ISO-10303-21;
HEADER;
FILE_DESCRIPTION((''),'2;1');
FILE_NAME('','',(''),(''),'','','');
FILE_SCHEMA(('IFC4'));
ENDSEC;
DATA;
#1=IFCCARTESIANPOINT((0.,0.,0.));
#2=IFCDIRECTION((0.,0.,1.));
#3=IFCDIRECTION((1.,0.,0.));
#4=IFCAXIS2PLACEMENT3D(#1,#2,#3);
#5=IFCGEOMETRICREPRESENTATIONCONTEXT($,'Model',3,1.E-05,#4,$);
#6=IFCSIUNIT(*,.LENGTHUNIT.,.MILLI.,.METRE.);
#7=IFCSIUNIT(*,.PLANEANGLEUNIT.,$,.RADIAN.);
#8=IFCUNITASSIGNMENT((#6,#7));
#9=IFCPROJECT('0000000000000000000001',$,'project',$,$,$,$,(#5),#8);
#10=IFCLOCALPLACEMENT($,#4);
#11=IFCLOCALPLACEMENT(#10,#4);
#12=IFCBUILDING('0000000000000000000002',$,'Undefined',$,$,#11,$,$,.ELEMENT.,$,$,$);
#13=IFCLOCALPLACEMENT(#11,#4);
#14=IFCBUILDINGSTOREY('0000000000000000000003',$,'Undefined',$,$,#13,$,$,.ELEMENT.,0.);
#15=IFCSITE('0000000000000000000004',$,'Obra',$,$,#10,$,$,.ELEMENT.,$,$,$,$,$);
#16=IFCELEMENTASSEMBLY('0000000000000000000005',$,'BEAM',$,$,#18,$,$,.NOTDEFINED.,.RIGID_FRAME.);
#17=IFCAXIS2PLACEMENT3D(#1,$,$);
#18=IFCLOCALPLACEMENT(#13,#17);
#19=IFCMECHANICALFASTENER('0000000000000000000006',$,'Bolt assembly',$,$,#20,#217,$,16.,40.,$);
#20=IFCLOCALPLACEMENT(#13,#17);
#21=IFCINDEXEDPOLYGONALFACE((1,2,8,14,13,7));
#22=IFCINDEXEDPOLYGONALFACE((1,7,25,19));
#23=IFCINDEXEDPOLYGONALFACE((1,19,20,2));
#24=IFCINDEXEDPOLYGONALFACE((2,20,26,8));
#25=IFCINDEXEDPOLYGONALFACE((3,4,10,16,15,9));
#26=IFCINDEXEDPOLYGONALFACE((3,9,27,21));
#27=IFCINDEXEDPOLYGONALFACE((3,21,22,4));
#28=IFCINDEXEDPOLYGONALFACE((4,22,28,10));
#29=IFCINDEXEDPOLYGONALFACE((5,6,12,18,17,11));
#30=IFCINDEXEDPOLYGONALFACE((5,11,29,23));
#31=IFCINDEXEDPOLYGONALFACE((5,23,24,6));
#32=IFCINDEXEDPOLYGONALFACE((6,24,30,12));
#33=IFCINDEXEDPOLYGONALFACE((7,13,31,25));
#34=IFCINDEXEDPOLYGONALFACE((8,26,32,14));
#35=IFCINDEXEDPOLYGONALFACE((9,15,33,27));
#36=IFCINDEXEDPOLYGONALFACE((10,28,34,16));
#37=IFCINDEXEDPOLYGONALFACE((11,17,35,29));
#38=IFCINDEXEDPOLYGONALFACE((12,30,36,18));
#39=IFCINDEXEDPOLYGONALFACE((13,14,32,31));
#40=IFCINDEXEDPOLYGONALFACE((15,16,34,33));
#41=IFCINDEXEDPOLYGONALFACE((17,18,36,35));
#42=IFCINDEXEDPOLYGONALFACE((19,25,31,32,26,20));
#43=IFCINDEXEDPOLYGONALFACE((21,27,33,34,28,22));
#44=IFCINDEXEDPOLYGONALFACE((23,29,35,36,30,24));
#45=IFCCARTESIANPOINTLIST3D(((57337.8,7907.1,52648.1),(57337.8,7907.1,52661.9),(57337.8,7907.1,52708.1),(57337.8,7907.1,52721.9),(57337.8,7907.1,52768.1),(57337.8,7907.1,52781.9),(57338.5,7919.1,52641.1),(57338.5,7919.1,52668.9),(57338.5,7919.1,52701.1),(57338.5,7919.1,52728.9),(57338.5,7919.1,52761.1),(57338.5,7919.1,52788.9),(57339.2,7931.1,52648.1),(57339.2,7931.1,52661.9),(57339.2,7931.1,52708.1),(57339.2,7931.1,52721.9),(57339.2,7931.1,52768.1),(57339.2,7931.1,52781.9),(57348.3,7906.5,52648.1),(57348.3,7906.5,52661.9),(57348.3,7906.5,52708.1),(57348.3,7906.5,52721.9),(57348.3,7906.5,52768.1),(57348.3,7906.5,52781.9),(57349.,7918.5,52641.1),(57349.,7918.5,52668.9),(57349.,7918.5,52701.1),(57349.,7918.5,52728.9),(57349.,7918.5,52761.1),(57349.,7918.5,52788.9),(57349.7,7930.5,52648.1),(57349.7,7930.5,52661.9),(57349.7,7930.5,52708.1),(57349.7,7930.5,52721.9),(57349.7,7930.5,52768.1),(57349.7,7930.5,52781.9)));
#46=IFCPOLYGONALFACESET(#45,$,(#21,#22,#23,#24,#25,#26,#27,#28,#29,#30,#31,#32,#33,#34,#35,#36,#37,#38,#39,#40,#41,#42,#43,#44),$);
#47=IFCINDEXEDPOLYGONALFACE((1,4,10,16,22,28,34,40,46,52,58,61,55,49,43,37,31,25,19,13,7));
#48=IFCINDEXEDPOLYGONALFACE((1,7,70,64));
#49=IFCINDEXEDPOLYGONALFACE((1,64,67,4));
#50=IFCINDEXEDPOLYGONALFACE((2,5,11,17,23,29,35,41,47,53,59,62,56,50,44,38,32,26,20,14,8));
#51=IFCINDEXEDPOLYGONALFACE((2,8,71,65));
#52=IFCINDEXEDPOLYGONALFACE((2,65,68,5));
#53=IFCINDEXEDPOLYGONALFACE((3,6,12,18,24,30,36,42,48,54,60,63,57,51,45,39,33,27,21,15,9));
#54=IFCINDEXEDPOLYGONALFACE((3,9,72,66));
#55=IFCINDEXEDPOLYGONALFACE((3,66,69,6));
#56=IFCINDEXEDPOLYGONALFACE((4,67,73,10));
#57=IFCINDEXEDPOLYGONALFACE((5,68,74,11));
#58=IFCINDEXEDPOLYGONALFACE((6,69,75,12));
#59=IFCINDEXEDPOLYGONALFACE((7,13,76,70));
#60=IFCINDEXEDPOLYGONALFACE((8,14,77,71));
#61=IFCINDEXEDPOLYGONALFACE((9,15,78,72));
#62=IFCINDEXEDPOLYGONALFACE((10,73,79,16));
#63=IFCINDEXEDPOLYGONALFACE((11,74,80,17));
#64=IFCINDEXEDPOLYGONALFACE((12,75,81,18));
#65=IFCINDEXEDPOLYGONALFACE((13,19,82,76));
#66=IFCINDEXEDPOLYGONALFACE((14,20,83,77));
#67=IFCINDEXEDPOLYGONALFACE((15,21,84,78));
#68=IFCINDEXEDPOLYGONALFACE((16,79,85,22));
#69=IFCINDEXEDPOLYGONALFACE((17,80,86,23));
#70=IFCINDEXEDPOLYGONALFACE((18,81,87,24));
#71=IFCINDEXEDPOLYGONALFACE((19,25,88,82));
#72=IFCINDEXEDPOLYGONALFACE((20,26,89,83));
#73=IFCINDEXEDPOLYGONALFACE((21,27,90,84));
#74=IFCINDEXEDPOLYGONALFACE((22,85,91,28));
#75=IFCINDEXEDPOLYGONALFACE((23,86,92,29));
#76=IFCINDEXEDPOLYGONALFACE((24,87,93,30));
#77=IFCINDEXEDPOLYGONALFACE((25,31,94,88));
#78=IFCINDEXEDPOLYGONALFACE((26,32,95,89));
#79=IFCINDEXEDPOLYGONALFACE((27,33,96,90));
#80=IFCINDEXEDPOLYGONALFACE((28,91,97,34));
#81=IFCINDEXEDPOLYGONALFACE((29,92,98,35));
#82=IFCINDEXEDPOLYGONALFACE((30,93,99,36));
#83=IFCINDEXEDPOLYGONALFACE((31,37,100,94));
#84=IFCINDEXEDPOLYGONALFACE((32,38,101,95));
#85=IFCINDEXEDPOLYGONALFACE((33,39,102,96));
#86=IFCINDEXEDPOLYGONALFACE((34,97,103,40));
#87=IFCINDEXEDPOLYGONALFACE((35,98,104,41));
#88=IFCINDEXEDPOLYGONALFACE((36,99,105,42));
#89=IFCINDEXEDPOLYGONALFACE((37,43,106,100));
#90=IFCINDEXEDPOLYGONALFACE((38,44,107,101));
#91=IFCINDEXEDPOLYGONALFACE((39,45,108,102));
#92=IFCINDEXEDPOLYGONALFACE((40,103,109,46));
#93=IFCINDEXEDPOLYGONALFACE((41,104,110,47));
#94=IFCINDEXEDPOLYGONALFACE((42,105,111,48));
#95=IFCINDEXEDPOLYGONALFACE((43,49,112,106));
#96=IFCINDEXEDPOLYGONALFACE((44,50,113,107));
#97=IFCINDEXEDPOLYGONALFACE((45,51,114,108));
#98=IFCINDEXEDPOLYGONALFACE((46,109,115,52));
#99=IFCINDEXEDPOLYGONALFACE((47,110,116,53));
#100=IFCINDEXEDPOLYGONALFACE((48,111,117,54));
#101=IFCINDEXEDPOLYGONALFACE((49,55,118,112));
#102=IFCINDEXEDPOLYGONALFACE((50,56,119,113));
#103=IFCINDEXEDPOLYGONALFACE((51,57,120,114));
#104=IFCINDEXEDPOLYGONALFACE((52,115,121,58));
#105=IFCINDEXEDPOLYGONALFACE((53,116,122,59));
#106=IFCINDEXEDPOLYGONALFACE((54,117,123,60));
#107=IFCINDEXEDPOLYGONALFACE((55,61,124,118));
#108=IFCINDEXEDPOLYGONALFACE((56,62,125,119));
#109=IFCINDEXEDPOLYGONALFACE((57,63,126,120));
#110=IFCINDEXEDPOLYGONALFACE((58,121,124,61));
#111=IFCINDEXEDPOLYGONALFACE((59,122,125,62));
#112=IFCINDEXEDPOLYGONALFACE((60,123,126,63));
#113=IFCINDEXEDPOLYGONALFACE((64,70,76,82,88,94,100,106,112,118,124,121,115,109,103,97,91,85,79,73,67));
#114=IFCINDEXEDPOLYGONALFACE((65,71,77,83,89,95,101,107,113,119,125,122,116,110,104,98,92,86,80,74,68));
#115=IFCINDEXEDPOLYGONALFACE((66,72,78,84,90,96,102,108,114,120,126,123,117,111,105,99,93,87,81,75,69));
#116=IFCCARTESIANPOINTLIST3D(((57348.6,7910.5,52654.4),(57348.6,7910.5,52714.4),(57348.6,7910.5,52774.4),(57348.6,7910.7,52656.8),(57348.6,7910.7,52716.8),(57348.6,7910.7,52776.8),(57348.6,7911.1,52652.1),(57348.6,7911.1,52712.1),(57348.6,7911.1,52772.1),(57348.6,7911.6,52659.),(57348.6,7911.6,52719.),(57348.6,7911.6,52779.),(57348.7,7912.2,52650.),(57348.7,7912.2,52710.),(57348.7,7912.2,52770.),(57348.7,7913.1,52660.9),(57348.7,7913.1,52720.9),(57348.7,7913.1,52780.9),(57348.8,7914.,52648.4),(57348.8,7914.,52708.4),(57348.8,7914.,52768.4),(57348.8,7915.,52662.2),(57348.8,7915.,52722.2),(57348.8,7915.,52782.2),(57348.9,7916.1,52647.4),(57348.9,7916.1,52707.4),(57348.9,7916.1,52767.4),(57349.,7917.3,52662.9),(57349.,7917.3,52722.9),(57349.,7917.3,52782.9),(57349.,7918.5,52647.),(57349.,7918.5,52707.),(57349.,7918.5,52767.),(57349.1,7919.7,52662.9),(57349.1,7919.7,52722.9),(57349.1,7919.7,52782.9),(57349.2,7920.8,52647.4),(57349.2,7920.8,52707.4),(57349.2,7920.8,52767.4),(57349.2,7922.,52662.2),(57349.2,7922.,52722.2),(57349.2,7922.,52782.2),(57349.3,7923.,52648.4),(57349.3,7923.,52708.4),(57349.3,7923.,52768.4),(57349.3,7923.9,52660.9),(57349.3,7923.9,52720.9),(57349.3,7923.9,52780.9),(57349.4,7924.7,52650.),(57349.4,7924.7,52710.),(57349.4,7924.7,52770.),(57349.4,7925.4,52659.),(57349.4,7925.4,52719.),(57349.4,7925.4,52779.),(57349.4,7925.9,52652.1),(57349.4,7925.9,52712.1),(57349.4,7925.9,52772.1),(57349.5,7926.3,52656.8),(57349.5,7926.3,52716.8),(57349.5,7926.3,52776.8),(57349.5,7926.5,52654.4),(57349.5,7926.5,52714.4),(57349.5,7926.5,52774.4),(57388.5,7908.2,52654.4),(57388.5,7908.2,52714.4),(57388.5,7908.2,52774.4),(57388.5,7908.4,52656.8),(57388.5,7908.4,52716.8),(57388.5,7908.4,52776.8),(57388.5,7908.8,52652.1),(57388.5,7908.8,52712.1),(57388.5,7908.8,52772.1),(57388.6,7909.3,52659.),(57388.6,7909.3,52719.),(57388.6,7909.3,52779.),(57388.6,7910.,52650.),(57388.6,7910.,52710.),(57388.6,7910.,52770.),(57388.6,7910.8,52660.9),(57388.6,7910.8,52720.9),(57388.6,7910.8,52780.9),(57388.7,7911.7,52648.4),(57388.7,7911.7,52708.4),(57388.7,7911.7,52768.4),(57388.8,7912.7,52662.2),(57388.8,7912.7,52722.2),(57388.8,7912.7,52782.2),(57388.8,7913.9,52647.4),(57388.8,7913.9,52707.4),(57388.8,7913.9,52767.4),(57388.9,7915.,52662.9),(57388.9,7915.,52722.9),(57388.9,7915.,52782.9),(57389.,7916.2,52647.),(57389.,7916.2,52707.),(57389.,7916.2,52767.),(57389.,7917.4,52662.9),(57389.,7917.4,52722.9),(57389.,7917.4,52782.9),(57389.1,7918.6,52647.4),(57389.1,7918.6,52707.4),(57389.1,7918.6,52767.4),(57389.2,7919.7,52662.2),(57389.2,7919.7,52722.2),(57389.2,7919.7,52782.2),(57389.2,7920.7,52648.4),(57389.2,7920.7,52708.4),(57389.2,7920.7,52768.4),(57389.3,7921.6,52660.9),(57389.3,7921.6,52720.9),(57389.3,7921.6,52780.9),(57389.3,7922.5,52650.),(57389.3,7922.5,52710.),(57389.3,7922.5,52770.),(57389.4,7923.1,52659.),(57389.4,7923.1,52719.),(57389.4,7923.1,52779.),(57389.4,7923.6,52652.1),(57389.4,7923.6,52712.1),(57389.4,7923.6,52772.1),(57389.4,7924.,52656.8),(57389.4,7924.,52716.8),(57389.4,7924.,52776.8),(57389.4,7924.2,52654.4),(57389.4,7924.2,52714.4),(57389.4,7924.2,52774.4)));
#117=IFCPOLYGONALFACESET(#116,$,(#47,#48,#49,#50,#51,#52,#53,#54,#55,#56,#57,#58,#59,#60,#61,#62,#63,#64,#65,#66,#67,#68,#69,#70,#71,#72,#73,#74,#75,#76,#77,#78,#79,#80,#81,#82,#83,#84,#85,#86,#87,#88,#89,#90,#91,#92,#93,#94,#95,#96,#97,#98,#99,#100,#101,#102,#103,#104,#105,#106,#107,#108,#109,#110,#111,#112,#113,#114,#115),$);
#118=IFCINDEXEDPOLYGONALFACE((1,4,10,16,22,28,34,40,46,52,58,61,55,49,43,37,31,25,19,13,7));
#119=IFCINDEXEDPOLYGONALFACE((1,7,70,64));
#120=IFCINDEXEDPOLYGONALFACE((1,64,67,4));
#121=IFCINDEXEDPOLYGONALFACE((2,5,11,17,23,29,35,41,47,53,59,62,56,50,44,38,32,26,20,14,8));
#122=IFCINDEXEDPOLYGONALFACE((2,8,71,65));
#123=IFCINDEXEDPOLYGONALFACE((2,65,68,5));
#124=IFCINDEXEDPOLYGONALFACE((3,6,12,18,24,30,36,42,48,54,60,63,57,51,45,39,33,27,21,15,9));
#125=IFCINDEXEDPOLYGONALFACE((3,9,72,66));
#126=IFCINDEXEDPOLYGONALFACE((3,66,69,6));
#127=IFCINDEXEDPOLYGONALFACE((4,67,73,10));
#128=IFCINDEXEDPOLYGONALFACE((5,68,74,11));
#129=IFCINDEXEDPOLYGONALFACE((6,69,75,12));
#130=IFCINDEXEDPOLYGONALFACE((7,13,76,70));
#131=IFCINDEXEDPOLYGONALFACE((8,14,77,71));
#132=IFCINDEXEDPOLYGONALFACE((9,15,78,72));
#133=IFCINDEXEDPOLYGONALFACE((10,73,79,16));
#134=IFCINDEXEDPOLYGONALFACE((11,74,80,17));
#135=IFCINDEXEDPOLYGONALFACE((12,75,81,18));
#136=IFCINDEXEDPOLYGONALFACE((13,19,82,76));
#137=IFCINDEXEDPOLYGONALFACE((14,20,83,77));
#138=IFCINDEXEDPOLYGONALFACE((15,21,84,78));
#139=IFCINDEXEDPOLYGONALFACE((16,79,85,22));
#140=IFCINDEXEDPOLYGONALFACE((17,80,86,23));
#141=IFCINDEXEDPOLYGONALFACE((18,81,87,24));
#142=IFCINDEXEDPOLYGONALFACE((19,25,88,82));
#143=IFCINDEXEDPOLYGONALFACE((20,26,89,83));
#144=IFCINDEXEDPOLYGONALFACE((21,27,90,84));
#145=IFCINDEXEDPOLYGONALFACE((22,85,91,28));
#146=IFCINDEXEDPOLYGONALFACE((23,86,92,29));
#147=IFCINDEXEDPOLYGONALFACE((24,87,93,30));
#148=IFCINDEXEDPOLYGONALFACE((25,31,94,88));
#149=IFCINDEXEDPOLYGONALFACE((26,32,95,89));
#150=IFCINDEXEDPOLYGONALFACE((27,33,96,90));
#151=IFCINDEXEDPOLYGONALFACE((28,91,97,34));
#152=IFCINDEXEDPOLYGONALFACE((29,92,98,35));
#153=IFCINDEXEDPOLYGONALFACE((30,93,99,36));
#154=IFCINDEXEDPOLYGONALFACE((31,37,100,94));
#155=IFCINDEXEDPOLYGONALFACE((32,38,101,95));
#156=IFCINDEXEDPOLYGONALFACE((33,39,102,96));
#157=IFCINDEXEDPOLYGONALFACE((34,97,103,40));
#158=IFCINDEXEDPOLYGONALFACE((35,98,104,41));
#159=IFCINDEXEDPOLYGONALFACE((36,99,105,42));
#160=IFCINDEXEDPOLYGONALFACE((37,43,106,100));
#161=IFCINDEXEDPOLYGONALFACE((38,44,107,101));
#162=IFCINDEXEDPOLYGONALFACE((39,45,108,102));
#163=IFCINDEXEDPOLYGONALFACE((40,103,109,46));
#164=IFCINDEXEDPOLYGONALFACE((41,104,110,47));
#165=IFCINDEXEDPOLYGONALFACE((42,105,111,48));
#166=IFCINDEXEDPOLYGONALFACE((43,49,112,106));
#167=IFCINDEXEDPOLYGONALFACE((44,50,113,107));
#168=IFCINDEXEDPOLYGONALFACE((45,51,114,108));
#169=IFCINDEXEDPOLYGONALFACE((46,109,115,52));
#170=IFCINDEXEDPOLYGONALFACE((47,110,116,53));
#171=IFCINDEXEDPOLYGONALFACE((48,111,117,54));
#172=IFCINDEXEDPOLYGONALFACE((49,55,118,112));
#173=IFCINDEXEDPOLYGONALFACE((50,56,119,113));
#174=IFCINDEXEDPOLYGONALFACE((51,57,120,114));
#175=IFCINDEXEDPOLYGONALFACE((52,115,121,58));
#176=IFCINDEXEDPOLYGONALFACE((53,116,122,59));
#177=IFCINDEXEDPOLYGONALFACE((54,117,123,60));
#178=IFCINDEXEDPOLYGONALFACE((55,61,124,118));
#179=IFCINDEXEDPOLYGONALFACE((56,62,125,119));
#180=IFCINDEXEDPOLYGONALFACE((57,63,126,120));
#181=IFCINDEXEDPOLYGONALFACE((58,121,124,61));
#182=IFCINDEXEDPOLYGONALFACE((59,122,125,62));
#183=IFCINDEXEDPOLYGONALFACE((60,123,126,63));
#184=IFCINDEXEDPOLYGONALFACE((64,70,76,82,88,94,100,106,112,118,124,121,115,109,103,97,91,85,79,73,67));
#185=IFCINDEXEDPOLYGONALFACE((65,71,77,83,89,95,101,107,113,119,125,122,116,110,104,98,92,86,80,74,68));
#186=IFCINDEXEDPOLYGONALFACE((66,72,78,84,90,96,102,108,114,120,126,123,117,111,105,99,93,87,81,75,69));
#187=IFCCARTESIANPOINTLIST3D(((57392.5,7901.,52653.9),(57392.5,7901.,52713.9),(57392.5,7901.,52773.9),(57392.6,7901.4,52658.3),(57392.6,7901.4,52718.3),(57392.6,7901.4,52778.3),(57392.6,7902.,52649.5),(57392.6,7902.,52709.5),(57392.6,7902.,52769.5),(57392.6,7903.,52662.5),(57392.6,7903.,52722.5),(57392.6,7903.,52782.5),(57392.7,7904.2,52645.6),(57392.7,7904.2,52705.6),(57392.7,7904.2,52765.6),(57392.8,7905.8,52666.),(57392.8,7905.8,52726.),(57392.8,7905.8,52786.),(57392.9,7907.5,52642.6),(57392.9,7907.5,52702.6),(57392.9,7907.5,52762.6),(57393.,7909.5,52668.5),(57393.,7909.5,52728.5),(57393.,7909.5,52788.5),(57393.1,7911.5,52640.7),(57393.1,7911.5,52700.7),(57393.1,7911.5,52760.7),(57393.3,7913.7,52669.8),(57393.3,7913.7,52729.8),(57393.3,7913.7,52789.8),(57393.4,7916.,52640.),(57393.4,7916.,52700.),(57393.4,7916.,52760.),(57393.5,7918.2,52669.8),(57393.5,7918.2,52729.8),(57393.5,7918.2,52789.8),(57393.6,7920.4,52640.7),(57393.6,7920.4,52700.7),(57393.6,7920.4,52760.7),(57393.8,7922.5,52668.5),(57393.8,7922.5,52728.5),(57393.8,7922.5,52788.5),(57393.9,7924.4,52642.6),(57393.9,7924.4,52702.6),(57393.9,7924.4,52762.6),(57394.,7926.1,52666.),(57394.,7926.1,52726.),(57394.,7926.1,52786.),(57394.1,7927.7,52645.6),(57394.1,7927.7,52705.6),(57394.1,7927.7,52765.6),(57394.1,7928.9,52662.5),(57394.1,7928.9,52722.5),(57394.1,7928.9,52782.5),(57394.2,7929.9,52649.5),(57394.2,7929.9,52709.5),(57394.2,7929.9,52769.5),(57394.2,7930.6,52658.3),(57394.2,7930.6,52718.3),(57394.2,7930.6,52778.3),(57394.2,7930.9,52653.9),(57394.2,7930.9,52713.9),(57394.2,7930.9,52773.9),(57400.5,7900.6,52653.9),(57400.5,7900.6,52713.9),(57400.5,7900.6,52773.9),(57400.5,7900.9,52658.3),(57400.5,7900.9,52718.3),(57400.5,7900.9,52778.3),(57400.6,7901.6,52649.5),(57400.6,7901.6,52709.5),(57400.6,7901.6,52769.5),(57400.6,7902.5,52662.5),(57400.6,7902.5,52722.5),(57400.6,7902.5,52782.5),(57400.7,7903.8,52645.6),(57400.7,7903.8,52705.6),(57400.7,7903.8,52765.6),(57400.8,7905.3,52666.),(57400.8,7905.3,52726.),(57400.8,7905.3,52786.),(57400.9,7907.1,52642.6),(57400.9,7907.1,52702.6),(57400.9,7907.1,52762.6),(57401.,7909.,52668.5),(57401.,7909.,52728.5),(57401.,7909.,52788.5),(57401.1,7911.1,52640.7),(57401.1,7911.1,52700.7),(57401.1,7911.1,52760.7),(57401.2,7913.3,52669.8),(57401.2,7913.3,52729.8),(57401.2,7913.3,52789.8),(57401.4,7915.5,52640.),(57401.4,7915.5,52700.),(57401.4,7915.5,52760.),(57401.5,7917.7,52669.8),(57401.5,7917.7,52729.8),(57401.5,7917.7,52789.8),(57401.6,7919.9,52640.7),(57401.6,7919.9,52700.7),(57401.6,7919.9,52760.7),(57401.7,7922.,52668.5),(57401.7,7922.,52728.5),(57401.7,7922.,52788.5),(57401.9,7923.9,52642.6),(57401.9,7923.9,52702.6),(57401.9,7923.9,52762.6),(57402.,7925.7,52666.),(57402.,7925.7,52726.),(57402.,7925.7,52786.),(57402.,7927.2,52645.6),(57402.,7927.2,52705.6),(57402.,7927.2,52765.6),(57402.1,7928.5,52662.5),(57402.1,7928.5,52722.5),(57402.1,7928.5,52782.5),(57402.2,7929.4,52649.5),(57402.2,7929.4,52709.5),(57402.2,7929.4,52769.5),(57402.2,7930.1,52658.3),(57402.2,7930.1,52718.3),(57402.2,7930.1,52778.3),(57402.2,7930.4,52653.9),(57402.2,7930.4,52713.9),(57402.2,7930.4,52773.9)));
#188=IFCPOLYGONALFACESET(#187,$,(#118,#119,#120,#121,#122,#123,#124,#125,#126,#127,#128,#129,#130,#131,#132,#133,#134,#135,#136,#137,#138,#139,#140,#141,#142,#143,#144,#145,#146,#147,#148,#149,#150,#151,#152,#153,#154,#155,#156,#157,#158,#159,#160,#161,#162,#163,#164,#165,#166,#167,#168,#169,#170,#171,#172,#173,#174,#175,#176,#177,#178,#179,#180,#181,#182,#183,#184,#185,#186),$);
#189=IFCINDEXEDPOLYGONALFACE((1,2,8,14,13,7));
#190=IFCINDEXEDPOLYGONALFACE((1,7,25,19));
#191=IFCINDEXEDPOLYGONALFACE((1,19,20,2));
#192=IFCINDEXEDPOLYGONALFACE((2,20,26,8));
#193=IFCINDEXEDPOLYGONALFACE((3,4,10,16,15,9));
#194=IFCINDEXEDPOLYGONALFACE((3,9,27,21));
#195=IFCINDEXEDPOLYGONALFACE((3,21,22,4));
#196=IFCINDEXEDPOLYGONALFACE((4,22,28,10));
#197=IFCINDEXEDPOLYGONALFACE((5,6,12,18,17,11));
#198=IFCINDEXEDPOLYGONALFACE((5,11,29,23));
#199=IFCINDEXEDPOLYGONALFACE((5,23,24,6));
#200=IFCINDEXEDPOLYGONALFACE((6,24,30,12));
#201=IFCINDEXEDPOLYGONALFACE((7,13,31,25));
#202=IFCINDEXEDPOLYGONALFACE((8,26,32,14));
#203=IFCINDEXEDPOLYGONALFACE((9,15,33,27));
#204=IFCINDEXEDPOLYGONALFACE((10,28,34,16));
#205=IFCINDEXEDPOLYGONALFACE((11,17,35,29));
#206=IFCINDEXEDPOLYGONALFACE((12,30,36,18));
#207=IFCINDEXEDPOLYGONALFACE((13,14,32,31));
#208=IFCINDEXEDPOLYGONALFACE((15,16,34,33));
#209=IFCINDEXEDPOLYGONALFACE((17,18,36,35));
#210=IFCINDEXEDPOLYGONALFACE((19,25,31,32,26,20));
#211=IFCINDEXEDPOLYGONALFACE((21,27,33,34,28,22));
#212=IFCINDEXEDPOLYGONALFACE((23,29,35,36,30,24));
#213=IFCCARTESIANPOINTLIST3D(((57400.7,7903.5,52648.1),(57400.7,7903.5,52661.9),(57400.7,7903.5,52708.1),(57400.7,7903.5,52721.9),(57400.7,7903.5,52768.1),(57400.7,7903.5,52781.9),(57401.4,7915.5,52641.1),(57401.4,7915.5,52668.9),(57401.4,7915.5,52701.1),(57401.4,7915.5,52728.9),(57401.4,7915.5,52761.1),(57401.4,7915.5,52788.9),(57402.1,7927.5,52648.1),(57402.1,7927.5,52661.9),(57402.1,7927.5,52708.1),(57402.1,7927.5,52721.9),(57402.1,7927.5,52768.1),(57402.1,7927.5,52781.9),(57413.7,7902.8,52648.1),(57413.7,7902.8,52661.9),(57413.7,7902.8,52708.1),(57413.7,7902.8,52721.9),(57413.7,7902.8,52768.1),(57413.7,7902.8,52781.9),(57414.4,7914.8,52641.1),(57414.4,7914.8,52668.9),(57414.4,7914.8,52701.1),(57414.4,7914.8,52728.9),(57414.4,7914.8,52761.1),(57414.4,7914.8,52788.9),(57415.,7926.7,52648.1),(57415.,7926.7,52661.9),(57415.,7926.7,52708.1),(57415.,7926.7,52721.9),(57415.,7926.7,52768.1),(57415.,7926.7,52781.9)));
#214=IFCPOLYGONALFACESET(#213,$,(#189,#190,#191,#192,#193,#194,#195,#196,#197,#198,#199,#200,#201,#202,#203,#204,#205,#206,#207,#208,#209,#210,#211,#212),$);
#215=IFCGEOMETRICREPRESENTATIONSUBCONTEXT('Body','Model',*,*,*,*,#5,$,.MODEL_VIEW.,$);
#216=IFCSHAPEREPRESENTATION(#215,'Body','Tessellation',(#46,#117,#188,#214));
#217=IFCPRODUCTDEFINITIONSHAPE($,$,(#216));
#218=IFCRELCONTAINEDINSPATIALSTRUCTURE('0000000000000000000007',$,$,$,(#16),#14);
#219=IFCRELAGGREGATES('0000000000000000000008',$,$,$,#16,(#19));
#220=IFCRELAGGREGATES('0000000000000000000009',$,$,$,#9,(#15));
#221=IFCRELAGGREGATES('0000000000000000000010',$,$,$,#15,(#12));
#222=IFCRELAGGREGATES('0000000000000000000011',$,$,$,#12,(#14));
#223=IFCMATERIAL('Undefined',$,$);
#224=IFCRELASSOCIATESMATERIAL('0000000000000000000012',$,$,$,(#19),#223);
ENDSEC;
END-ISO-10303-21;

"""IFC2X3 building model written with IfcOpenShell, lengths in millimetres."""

from ifc_helpers import new_model, si_unit, frame, origin_with_axes, origin_2d_with_axis, place, context, subcontext, project, spatial, polyline, circle, outline, extrude, source, transform, mapped, material, element, aggregate, save


model = new_model("IFC2X3")

# Units and contexts
model_context = context("Model", 3, precision=1e-05, world=origin_with_axes())
body_context = subcontext(model_context, "Body", "Model", "MODEL_VIEW")
ifc_project = project(units=[si_unit("LENGTHUNIT", "METRE", prefix="MILLI"), si_unit("PLANEANGLEUNIT", "RADIAN")], contexts=[model_context])

# Site, building, storey
site_placement = place(None, origin_with_axes())
site = spatial("IfcSite", under=ifc_project, at=site_placement, Name="Obra", CompositionType="ELEMENT")
building_placement = place(site_placement, origin_with_axes())
building = spatial("IfcBuilding", under=site, at=building_placement, Name="Undefined", CompositionType="ELEMENT")
storey_placement = place(building_placement, origin_with_axes())
storey = spatial("IfcBuildingStorey", under=building, at=storey_placement, Name="Undefined", CompositionType="ELEMENT", Elevation=0.0)

# Element assembly
assembly_1_placement = place(storey_placement, origin_with_axes())
assembly_1 = element("IfcElementAssembly", 1, at=assembly_1_placement, inside=storey, Name="BEAM", AssemblyPlace="NOTDEFINED", PredefinedType="RIGID_FRAME")

# Mechanical fastener
ifc_material_1 = material(Name="Undefined")
shared_shape_1 = source(origin_with_axes(), body_context, "Body", "SweptSolid", [
    extrude(outline(polyline([(13.9, 0.0), (6.9, 12.0), (-6.9, 12.0), (-13.9, 0.0), (-6.9, -12.0), (6.9, -12.0), (13.9, 0.0)])), frame((0.0, -19.7, 0.0), z_axis=(0.0, 1.0, 0.0), x_axis=(1.0, 0.0, 0.0)), (0.0, 0.0, 1.0), 10.6),
    extrude(circle(Radius=8.0, at=origin_2d_with_axis()), frame((0.0, -9.1, 0.0), z_axis=(0.0, 1.0, 0.0), x_axis=(1.0, 0.0, 0.0)), (0.0, 0.0, 1.0), 40.0),
    extrude(circle(Radius=15.0, at=origin_2d_with_axis()), frame((0.0, 35.3, 0.0), z_axis=(0.0, 1.0, 0.0), x_axis=(1.0, 0.0, 0.0)), (0.0, 0.0, 1.0), 8.0),
    extrude(outline(polyline([(13.9, 0.0), (6.9, 12.0), (-6.9, 12.0), (-13.9, 0.0), (-6.9, -12.0), (6.9, -12.0), (13.9, 0.0)])), frame((0.0, 43.3, 0.0), z_axis=(0.0, 1.0, 0.0), x_axis=(1.0, 0.0, 0.0)), (0.0, 0.0, 1.0), 13.0),
])
mechanical_fastener_1_placement = place(assembly_1_placement, frame((57361.0, 7967.9, 52835.0), z_axis=(-0.05711, -0.998368, 0.0), x_axis=(0.0, 0.0, -1.0)))
mechanical_fastener_1 = element("IfcMechanicalFastener", 2, at=mechanical_fastener_1_placement, material=ifc_material_1, Name="Bolt assembly", NominalDiameter=16.0, NominalLength=40.0, context=body_context, shape_type="MappedRepresentation", body=[
    mapped(shared_shape_1, transform((60.0, 0.0, 50.0))),
    mapped(shared_shape_1, transform((120.0, 0.0, 50.0))),
    mapped(shared_shape_1, transform((180.0, 0.0, 50.0))),
])
aggregate(assembly_1, [mechanical_fastener_1])

save(model, "model.ifc")
